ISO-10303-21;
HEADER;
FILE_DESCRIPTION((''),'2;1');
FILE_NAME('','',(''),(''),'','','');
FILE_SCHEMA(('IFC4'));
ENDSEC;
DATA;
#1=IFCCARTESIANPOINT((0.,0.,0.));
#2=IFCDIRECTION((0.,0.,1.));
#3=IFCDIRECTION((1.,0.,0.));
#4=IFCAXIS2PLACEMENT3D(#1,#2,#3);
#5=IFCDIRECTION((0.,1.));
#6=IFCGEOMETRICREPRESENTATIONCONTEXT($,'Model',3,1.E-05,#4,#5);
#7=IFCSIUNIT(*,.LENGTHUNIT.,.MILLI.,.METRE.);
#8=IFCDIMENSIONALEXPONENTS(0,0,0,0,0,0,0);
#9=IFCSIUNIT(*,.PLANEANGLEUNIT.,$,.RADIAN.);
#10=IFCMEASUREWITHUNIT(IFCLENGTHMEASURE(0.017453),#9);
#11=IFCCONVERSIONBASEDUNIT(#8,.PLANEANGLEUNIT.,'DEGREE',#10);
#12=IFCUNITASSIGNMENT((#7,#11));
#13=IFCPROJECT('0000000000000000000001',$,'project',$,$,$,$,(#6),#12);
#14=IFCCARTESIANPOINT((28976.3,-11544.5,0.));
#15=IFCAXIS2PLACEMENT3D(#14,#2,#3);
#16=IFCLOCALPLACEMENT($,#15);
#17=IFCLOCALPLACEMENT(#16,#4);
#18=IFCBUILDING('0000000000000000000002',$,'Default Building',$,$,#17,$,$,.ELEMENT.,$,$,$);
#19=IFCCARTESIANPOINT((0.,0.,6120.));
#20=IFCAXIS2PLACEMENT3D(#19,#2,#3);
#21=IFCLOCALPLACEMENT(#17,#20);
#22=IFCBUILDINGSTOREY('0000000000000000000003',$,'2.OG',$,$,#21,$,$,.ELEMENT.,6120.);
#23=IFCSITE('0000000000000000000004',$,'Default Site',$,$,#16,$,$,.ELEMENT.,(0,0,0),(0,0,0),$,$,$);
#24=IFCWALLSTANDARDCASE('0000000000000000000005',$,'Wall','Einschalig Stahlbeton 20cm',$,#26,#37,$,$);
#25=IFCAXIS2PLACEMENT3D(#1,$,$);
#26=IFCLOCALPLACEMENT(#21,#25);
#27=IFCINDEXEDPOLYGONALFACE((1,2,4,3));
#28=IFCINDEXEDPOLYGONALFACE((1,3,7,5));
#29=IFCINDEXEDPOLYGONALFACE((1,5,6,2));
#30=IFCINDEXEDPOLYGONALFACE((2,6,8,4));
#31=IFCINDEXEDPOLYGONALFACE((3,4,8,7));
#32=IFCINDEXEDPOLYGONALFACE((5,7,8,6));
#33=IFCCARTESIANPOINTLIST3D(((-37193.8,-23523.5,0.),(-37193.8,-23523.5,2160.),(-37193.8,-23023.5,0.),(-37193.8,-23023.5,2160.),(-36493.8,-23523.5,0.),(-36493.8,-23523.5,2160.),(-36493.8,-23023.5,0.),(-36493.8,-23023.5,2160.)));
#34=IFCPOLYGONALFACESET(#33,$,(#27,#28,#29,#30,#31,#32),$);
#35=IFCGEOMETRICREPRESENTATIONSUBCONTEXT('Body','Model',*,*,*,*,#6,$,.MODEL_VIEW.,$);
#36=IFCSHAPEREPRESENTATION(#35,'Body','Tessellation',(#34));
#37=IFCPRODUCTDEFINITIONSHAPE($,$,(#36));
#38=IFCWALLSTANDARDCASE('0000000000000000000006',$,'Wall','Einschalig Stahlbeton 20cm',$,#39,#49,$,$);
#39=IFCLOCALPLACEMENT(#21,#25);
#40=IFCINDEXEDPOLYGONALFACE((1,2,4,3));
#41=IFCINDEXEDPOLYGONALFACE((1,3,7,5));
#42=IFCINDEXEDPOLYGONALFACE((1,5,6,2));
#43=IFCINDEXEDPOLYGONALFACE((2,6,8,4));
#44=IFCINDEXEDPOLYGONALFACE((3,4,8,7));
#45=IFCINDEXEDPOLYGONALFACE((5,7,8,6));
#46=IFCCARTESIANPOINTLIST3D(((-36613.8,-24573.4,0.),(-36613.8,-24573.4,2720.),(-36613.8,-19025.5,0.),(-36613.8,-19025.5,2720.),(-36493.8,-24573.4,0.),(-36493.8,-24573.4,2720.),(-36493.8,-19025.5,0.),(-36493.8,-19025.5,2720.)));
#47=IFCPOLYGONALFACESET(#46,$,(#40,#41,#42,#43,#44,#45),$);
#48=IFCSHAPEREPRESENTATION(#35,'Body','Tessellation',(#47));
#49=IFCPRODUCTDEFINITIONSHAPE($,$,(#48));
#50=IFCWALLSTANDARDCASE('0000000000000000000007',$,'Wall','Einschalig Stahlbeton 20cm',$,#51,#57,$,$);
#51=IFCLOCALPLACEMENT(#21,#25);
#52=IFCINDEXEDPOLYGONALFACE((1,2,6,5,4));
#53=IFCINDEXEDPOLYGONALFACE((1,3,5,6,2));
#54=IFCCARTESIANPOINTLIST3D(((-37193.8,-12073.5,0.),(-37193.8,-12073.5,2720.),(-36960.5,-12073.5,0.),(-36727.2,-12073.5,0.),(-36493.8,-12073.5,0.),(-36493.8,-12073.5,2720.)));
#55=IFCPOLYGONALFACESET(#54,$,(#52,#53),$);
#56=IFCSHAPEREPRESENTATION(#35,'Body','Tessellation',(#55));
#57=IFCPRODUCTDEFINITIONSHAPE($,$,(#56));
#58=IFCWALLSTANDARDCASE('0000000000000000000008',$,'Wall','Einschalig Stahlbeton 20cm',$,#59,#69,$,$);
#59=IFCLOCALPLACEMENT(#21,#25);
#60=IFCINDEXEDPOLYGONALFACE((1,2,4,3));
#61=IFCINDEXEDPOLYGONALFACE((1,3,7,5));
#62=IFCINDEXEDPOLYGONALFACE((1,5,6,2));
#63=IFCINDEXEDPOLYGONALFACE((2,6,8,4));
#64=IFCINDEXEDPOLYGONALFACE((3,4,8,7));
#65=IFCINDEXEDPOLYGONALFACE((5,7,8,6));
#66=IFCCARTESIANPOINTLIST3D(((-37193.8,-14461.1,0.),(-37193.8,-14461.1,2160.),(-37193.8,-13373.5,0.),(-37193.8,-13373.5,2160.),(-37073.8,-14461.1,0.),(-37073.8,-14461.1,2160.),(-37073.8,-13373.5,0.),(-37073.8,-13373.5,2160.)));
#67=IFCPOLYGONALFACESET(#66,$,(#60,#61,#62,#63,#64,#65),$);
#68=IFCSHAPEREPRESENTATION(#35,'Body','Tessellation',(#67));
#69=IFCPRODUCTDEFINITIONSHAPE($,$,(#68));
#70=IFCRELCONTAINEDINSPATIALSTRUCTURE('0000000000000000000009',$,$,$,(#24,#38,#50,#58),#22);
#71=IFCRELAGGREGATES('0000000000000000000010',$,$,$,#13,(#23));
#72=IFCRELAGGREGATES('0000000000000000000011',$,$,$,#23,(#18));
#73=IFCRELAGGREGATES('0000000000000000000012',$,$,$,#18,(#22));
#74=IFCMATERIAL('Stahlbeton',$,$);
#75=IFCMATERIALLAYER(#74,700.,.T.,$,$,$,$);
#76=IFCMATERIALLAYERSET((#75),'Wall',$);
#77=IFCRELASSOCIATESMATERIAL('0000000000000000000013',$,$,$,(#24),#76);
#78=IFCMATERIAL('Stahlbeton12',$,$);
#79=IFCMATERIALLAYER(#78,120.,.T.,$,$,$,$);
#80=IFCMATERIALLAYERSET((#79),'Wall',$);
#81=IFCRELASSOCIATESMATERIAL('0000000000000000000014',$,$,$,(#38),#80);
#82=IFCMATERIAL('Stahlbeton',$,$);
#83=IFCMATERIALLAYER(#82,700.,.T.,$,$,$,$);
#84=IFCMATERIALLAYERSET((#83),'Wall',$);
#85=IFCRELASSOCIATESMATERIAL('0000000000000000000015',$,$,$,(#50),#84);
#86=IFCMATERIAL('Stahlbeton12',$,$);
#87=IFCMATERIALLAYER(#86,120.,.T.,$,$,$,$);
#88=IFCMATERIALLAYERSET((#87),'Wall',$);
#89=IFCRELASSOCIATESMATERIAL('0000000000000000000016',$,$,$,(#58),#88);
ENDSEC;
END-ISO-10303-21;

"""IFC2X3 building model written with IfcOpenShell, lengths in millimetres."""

from ifc_helpers import new_model, entity, si_unit, converted_unit, direction, frame, origin_with_axes, place, context, subcontext, project, spatial, polyline, outline, extrude, material, layer, layer_set, layer_usage, element, save


model = new_model("IFC2X3")

# Units and contexts
model_context = context("Model", 3, precision=1e-05, world=origin_with_axes(), true_north=direction((0.0, 1.0)))
body_context = subcontext(model_context, "Body", "Model", "MODEL_VIEW")
ifc_project = project(units=[si_unit("LENGTHUNIT", "METRE", prefix="MILLI"), converted_unit("PLANEANGLEUNIT", "DEGREE", entity("IfcLengthMeasure", 0.017453), si_unit("PLANEANGLEUNIT", "RADIAN"), dimensions=[0, 0, 0, 0, 0, 0, 0])], contexts=[model_context])

# Site, building, storey
site_placement = place(None, frame((28976.3, -11544.5, 0.0), z_axis=(0.0, 0.0, 1.0), x_axis=(1.0, 0.0, 0.0)))
site = spatial("IfcSite", under=ifc_project, at=site_placement, Name="Default Site", CompositionType="ELEMENT", RefLatitude=(0, 0, 0), RefLongitude=(0, 0, 0))
building_placement = place(site_placement, origin_with_axes())
building = spatial("IfcBuilding", under=site, at=building_placement, Name="Default Building", CompositionType="ELEMENT")
storey_placement = place(building_placement, frame((0.0, 0.0, 6120.0), z_axis=(0.0, 0.0, 1.0), x_axis=(1.0, 0.0, 0.0)))
storey = spatial("IfcBuildingStorey", under=building, at=storey_placement, Name="2.OG", CompositionType="ELEMENT", Elevation=6120.0)

# Walls
ifc_material_1 = material(Name="Stahlbeton")
ifc_layer_1 = layer(ifc_material_1, 700.0, ventilated=True)
ifc_layer_set_1 = layer_set([ifc_layer_1], Name="Wall")
ifc_layer_usage_1 = layer_usage(ifc_layer_set_1, "AXIS2", "POSITIVE", -350.0)
wall_1_placement = place(storey_placement, frame((-36843.8, -23523.5, 0.0), z_axis=(0.0, 0.0, 1.0), x_axis=(0.0, 1.0, 0.0)))
element("IfcWallStandardCase", 1, at=wall_1_placement, inside=storey, material=ifc_layer_usage_1, Name="Wall", Description="Einschalig Stahlbeton 20cm", context=body_context, shape_type="SweptSolid", body=[
    extrude(outline(polyline([(0.0, -350.0), (0.0, 350.0), (500.0, 350.0), (500.0, -350.0), (0.0, -350.0)])), origin_with_axes(), (0.0, 0.0, 1.0), 2160.0),
])
ifc_material_2 = material(Name="Stahlbeton12")
ifc_layer_2 = layer(ifc_material_2, 120.0, ventilated=True)
ifc_layer_set_2 = layer_set([ifc_layer_2], Name="Wall")
ifc_layer_usage_2 = layer_usage(ifc_layer_set_2, "AXIS2", "POSITIVE", -60.0)
wall_2_placement = place(storey_placement, frame((-36553.8, -24573.4, 0.0), z_axis=(0.0, 0.0, 1.0), x_axis=(0.0, 1.0, 0.0)))
element("IfcWallStandardCase", 2, at=wall_2_placement, inside=storey, material=ifc_layer_usage_2, Name="Wall", Description="Einschalig Stahlbeton 20cm", context=body_context, shape_type="SweptSolid", body=[
    extrude(outline(polyline([(0.0, -60.0), (0.0, 60.0), (5548.0, 60.0), (5548.0, -60.0), (0.0, -60.0)])), origin_with_axes(), (0.0, 0.0, 1.0), 2720.0),
])
ifc_material_3 = material(Name="Stahlbeton")
ifc_layer_3 = layer(ifc_material_3, 700.0, ventilated=True)
ifc_layer_set_3 = layer_set([ifc_layer_3], Name="Wall")
ifc_layer_usage_3 = layer_usage(ifc_layer_set_3, "AXIS2", "POSITIVE", -350.0)
wall_3_placement = place(storey_placement, frame((-36843.8, -12073.5, 0.0), z_axis=(0.0, 0.0, 1.0), x_axis=(0.0, 1.0, 0.0)))
element("IfcWallStandardCase", 3, at=wall_3_placement, inside=storey, material=ifc_layer_usage_3, Name="Wall", Description="Einschalig Stahlbeton 20cm", context=body_context, shape_type="SweptSolid", body=[
    extrude(outline(polyline([(0.0, -350.0), (0.0, 350.0), (0.0, 350.0), (0.0, -350.0), (0.0, -350.0)])), origin_with_axes(), (0.0, 0.0, 1.0), 2720.0),
])
ifc_material_4 = material(Name="Stahlbeton12")
ifc_layer_4 = layer(ifc_material_4, 120.0, ventilated=True)
ifc_layer_set_4 = layer_set([ifc_layer_4], Name="Wall")
ifc_layer_usage_4 = layer_usage(ifc_layer_set_4, "AXIS2", "POSITIVE", -60.0)
wall_4_placement = place(storey_placement, frame((-37133.8, -13373.5, 0.0), z_axis=(0.0, 0.0, 1.0), x_axis=(0.0, -1.0, 0.0)))
element("IfcWallStandardCase", 4, at=wall_4_placement, inside=storey, material=ifc_layer_usage_4, Name="Wall", Description="Einschalig Stahlbeton 20cm", context=body_context, shape_type="SweptSolid", body=[
    extrude(outline(polyline([(0.0, -60.0), (0.0, 60.0), (1087.7, 60.0), (1087.7, -60.0), (0.0, -60.0)])), origin_with_axes(), (0.0, 0.0, 1.0), 2160.0),
])

save(model, "model.ifc")
